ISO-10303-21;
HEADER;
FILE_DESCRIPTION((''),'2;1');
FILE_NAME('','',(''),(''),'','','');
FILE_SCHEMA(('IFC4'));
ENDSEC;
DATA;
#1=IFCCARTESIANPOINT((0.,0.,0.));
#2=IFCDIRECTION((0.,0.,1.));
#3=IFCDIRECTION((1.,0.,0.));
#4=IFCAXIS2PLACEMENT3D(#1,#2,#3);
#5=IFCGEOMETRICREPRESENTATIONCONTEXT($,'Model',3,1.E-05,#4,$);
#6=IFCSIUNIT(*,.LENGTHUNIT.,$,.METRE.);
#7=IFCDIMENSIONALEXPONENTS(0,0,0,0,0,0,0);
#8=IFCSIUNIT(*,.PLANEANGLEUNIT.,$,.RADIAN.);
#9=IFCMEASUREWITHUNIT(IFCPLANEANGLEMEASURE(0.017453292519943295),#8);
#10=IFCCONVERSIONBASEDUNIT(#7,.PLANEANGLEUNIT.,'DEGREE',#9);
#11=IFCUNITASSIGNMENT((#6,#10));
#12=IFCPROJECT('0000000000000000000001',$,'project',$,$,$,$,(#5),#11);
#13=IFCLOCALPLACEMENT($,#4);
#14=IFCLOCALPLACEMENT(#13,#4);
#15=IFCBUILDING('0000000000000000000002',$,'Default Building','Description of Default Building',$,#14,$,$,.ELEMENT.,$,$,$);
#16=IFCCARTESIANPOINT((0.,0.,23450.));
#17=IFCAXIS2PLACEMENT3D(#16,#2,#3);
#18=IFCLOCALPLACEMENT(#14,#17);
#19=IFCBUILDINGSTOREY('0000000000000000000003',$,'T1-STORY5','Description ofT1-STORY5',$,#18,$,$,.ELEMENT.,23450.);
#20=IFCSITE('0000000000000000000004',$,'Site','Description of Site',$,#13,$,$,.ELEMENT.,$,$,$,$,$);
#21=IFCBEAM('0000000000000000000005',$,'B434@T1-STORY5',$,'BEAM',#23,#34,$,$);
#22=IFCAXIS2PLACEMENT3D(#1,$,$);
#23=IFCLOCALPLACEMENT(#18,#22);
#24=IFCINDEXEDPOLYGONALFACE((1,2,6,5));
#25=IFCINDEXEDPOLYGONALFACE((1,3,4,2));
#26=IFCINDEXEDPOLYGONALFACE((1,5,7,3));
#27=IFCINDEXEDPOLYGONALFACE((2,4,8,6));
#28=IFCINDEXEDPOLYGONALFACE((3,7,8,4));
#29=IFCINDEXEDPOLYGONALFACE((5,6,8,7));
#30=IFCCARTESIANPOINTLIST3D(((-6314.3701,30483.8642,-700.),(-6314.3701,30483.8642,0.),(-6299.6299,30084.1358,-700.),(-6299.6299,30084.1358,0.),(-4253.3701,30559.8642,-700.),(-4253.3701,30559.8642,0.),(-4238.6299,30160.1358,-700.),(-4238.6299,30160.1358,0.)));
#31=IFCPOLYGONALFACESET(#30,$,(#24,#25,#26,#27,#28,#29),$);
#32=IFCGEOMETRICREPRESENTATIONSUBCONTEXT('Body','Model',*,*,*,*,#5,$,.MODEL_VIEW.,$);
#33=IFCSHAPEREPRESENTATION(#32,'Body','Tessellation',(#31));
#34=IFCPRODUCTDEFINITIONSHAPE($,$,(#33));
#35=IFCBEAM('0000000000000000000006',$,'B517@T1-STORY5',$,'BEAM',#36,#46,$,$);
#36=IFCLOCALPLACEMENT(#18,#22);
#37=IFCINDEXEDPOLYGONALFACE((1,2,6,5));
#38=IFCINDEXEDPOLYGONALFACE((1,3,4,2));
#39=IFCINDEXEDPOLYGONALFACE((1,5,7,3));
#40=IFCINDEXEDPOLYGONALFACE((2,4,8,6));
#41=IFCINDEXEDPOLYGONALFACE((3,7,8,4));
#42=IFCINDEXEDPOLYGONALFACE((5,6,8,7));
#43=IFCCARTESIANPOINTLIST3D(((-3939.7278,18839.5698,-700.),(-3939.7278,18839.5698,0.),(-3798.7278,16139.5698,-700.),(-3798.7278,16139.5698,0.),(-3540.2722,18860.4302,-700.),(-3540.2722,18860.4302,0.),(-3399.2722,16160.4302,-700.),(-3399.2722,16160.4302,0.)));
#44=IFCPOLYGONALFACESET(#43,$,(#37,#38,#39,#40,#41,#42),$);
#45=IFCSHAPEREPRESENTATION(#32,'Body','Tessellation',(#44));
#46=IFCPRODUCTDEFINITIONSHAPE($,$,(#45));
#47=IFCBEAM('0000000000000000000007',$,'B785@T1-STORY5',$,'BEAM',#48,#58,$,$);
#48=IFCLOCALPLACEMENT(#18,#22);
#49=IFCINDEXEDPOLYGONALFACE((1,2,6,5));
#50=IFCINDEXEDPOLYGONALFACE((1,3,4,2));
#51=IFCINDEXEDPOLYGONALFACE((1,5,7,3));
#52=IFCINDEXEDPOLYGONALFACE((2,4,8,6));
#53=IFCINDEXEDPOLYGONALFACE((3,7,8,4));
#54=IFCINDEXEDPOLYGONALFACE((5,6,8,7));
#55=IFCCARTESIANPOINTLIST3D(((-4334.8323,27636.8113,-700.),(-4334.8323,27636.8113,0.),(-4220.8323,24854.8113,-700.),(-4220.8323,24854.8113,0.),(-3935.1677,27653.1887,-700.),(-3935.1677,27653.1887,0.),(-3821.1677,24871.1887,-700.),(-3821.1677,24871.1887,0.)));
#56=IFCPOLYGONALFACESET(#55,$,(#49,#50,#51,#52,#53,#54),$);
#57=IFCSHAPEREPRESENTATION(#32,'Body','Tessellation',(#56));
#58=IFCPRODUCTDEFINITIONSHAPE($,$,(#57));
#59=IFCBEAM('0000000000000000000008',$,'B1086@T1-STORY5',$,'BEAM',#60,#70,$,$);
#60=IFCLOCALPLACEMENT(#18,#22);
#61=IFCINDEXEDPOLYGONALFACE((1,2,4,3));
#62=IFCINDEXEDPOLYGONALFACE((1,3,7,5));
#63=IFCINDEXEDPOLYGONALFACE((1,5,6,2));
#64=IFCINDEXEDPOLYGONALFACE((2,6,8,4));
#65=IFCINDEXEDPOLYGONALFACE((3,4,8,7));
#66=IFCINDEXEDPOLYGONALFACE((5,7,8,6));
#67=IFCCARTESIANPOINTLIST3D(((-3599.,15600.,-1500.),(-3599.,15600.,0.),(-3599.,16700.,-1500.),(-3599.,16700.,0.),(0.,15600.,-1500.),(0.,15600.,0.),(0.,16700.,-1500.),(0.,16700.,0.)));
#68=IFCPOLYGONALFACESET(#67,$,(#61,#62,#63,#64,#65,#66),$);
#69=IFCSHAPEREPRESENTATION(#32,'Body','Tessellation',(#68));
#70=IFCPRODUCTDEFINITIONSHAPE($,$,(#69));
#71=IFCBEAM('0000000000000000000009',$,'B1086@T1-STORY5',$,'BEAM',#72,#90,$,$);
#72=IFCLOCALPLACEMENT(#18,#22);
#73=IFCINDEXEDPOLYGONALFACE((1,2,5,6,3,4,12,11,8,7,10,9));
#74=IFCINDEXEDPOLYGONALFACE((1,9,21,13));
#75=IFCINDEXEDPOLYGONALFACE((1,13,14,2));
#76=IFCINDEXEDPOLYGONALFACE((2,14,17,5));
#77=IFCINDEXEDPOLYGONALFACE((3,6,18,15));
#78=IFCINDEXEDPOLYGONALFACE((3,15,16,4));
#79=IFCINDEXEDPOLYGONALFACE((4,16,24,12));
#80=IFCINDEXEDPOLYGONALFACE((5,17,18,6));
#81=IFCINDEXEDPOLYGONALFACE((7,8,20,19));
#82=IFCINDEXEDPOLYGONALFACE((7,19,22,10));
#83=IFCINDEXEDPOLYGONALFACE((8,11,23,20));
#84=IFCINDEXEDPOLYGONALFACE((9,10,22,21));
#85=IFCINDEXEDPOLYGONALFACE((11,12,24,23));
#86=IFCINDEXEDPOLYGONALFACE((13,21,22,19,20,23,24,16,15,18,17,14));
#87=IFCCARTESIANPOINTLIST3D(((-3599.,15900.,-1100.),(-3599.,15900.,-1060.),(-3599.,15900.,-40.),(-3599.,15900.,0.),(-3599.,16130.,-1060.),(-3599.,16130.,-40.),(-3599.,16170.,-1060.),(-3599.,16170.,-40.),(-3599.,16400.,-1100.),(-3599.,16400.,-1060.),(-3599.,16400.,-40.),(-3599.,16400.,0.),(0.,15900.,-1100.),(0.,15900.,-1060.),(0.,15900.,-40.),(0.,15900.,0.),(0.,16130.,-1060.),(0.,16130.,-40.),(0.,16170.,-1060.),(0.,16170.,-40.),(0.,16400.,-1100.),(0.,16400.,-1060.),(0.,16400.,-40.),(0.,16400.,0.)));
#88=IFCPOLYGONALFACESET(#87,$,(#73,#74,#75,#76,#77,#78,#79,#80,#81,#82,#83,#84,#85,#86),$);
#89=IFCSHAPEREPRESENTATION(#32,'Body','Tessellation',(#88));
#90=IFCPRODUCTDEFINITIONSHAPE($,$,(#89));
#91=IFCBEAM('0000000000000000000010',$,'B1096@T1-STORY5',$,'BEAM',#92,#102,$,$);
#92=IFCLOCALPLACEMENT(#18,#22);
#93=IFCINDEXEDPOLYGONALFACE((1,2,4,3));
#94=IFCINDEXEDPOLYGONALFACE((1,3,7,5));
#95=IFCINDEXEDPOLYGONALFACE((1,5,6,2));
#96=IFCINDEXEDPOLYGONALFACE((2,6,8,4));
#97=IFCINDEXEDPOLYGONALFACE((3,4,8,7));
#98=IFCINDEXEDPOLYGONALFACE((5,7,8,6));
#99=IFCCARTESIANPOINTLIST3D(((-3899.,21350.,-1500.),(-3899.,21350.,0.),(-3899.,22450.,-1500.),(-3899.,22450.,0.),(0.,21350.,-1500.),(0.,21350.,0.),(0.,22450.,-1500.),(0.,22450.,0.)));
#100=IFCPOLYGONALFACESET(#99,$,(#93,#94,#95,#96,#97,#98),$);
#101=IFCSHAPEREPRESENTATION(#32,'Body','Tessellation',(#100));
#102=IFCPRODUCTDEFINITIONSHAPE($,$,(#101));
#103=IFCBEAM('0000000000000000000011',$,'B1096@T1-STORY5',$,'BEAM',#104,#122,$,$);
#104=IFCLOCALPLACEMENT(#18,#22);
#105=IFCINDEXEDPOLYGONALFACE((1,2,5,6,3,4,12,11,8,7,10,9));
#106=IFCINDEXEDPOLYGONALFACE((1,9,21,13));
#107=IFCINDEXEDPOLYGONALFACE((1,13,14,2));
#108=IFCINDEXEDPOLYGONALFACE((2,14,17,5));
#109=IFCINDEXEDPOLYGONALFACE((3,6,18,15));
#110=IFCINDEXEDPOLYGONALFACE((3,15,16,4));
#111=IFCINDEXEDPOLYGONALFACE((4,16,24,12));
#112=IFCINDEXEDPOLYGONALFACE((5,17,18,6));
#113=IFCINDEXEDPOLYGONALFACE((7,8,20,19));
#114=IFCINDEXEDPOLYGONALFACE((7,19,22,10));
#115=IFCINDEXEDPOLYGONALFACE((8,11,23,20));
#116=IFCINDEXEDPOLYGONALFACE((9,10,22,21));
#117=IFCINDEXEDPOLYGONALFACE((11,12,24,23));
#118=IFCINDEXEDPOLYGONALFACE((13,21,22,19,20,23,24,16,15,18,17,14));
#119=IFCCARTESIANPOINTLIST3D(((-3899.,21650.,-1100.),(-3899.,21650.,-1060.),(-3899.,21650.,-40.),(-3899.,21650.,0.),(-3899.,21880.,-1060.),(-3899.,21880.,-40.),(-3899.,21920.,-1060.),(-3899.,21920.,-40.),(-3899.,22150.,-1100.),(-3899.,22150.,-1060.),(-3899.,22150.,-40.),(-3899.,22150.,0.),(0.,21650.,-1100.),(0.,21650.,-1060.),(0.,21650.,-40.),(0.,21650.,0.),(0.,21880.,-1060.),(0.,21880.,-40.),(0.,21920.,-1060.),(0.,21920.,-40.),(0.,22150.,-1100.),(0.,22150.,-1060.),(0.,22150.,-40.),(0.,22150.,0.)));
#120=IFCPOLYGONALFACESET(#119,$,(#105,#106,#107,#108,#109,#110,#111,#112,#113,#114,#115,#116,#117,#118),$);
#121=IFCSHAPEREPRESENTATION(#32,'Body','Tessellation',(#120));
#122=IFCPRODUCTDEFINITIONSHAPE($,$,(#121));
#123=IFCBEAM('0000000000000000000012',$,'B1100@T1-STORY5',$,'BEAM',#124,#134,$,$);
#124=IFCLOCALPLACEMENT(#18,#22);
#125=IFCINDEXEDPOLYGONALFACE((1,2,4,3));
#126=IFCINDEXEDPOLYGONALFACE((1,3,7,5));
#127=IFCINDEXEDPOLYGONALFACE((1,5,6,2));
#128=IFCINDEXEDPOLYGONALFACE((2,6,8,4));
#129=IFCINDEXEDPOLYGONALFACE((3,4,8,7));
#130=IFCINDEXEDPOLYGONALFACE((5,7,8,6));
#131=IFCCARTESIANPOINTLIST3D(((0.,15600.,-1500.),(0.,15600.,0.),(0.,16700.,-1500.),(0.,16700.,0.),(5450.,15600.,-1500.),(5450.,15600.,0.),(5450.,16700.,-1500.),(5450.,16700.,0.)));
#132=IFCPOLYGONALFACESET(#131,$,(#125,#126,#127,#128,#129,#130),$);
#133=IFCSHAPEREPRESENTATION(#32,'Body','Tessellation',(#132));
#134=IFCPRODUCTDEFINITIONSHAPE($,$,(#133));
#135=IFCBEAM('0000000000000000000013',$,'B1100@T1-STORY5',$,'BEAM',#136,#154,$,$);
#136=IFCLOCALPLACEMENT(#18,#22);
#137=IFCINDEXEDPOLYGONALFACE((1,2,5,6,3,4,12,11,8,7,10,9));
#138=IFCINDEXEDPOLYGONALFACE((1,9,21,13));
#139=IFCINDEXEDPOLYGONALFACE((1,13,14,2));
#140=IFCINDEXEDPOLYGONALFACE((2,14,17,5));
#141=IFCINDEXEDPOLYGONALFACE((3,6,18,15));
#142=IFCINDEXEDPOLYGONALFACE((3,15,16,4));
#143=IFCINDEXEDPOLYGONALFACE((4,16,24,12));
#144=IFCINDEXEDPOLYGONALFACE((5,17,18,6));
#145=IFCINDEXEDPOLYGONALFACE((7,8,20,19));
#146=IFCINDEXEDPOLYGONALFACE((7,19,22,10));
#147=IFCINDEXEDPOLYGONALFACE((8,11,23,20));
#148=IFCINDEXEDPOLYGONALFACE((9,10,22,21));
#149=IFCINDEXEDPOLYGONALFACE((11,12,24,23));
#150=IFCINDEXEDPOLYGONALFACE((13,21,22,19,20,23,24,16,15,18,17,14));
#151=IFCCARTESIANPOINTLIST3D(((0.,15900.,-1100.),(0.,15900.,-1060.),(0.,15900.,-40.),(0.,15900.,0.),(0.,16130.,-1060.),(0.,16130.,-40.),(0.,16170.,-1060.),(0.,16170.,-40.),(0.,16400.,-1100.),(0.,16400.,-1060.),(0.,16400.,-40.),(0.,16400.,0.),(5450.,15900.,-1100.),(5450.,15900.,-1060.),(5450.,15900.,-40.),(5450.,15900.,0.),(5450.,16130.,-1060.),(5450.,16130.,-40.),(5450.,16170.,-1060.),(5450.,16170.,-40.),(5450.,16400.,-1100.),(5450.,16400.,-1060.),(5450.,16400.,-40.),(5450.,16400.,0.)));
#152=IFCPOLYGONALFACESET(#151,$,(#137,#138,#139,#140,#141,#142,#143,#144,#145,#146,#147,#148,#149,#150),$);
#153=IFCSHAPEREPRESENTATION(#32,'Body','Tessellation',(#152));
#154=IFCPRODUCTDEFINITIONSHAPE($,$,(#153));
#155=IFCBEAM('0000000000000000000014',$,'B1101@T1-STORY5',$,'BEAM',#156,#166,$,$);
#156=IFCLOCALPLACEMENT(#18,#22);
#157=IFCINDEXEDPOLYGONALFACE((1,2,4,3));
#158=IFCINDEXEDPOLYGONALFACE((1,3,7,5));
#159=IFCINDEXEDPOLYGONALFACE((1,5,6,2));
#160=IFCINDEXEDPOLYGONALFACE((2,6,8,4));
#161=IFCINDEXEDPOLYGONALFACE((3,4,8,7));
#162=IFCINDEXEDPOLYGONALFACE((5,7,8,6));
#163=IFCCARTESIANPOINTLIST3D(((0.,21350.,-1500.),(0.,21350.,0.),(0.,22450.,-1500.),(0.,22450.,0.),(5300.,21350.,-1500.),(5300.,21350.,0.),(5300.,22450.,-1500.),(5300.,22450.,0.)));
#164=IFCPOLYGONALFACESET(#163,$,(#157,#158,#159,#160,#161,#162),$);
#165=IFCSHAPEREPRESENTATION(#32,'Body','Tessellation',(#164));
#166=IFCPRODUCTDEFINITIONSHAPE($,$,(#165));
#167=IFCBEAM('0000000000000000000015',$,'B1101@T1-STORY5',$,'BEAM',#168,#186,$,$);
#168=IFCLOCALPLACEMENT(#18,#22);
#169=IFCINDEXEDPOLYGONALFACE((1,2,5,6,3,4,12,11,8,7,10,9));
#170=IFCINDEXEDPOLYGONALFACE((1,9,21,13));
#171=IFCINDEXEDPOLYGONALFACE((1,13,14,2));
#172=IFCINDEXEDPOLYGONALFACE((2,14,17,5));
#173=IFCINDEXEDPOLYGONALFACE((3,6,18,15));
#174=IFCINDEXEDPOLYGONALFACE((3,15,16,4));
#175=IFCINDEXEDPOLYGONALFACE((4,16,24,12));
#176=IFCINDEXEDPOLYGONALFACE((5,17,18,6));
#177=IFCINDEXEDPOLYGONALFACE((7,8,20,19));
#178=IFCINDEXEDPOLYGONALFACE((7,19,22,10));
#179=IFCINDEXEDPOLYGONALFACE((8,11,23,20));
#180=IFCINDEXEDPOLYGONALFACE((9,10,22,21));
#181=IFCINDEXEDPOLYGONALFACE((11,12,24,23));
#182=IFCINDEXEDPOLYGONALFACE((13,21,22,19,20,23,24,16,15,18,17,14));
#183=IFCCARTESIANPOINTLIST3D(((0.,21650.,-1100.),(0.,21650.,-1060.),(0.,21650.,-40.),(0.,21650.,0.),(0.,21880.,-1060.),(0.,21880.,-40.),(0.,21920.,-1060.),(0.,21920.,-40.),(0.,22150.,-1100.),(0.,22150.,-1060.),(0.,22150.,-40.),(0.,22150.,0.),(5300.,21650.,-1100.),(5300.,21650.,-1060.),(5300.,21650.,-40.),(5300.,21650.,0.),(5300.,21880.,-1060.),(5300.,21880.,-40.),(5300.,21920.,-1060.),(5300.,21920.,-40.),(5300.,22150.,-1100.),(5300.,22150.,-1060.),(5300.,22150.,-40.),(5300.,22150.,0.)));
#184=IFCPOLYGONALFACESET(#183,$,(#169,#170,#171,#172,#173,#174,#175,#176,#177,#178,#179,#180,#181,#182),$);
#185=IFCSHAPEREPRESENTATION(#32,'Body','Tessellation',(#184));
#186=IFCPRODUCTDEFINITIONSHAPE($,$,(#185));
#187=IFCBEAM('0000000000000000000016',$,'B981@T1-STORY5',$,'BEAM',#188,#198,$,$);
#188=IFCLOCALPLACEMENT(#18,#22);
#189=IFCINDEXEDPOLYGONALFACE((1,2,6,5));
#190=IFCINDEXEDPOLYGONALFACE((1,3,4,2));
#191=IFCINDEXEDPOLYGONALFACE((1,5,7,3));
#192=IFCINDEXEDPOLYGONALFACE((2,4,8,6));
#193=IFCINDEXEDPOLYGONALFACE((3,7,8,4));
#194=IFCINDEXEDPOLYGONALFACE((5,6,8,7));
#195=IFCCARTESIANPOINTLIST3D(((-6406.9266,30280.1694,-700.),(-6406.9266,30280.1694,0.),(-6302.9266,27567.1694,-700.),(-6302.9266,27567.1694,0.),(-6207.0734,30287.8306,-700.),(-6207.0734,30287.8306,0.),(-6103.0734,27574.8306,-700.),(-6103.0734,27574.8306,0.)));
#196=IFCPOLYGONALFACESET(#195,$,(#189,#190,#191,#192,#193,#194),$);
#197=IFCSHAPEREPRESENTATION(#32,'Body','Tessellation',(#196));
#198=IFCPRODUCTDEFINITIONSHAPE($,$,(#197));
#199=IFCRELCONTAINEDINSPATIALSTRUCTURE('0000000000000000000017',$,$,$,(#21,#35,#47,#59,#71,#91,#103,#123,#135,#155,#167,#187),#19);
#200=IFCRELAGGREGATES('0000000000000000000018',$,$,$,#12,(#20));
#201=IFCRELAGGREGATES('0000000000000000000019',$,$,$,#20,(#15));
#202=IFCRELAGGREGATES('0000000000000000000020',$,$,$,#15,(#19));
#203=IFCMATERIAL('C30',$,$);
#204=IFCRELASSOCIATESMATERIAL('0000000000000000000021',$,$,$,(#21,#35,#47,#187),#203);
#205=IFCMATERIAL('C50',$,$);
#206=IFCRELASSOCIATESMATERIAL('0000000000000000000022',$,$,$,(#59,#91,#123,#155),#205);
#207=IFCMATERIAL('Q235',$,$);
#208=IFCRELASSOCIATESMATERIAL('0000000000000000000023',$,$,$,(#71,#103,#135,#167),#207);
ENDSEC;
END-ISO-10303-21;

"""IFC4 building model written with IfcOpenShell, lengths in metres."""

from ifc_helpers import new_model, entity, si_unit, converted_unit, frame, origin_with_axes, place, context, subcontext, project, spatial, rectangle, i_section, extrude, material, element, save


model = new_model("IFC4")

# Units and contexts
model_context = context("Model", 3, precision=1e-05, world=origin_with_axes())
body_context = subcontext(model_context, "Body", "Model", "MODEL_VIEW")
ifc_project = project(units=[si_unit("LENGTHUNIT", "METRE"), converted_unit("PLANEANGLEUNIT", "DEGREE", entity("IfcPlaneAngleMeasure", 0.017453292519943295), si_unit("PLANEANGLEUNIT", "RADIAN"), dimensions=[0, 0, 0, 0, 0, 0, 0])], contexts=[model_context])

# Site, building, storey
site_placement = place(None, origin_with_axes())
site = spatial("IfcSite", under=ifc_project, at=site_placement, Name="Site", Description="Description of Site", CompositionType="ELEMENT")
building_placement = place(site_placement, origin_with_axes())
building = spatial("IfcBuilding", under=site, at=building_placement, Name="Default Building", Description="Description of Default Building", CompositionType="ELEMENT")
storey_placement = place(building_placement, frame((0.0, 0.0, 23450.0), z_axis=(0.0, 0.0, 1.0), x_axis=(1.0, 0.0, 0.0)))
storey = spatial("IfcBuildingStorey", under=building, at=storey_placement, Name="T1-STORY5", Description="Description ofT1-STORY5", CompositionType="ELEMENT", Elevation=23450.0)

# Beams
ifc_material_1 = material(Name="C30")
beam_1_placement = place(storey_placement, frame((-6307.0, 30284.0, -350.0), z_axis=(0.999321, 0.03685, 0.0), x_axis=(-0.03685, 0.999321, 0.0)))
element("IfcBeam", 1, at=beam_1_placement, inside=storey, material=ifc_material_1, Name="B434@T1-STORY5", ObjectType="BEAM", context=body_context, shape_type="SweptSolid", body=[
    extrude(rectangle(XDim=400.0, YDim=700.0), origin_with_axes(), (0.0, 0.0, 1.0), 2062.4008),
])
beam_2_placement = place(storey_placement, frame((-3740.0, 18850.0, -350.0), z_axis=(0.052151, -0.998639, 0.0), x_axis=(0.998639, 0.052151, 0.0)))
element("IfcBeam", 2, at=beam_2_placement, inside=storey, material=ifc_material_1, Name="B517@T1-STORY5", ObjectType="BEAM", context=body_context, shape_type="SweptSolid", body=[
    extrude(rectangle(XDim=400.0, YDim=700.0), origin_with_axes(), (0.0, 0.0, 1.0), 2703.6792),
])
beam_3_placement = place(storey_placement, frame((-4135.0, 27645.0, -350.0), z_axis=(0.040943, -0.999161, 0.0), x_axis=(0.999161, 0.040943, 0.0)))
element("IfcBeam", 3, at=beam_3_placement, inside=storey, material=ifc_material_1, Name="B785@T1-STORY5", ObjectType="BEAM", context=body_context, shape_type="SweptSolid", body=[
    extrude(rectangle(XDim=400.0, YDim=700.0), origin_with_axes(), (0.0, 0.0, 1.0), 2784.3347),
])
ifc_material_2 = material(Name="C50")
beam_4_placement = place(storey_placement, frame((-3599.0, 16150.0, -750.0), z_axis=(1.0, 0.0, 0.0), x_axis=(0.0, 1.0, 0.0)))
element("IfcBeam", 4, at=beam_4_placement, inside=storey, material=ifc_material_2, Name="B1086@T1-STORY5", ObjectType="BEAM", context=body_context, shape_type="SweptSolid", body=[
    extrude(rectangle(XDim=1100.0, YDim=1500.0), origin_with_axes(), (0.0, 0.0, 1.0), 3599.0),
])
ifc_material_3 = material(Name="Q235")
beam_5_placement = place(storey_placement, frame((-3599.0, 16150.0, -550.0), z_axis=(1.0, 0.0, 0.0), x_axis=(0.0, 1.0, 0.0)))
element("IfcBeam", 5, at=beam_5_placement, inside=storey, material=ifc_material_3, Name="B1086@T1-STORY5", ObjectType="BEAM", context=body_context, shape_type="SweptSolid", body=[
    extrude(i_section(OverallWidth=500.0, OverallDepth=1100.0, WebThickness=40.0, FlangeThickness=40.0, FilletRadius=0.0), origin_with_axes(), (0.0, 0.0, 1.0), 3599.0),
])
beam_6_placement = place(storey_placement, frame((-3899.0, 21900.0, -750.0), z_axis=(1.0, 0.0, 0.0), x_axis=(0.0, 1.0, 0.0)))
element("IfcBeam", 6, at=beam_6_placement, inside=storey, material=ifc_material_2, Name="B1096@T1-STORY5", ObjectType="BEAM", context=body_context, shape_type="SweptSolid", body=[
    extrude(rectangle(XDim=1100.0, YDim=1500.0), origin_with_axes(), (0.0, 0.0, 1.0), 3899.0),
])
beam_7_placement = place(storey_placement, frame((-3899.0, 21900.0, -550.0), z_axis=(1.0, 0.0, 0.0), x_axis=(0.0, 1.0, 0.0)))
element("IfcBeam", 7, at=beam_7_placement, inside=storey, material=ifc_material_3, Name="B1096@T1-STORY5", ObjectType="BEAM", context=body_context, shape_type="SweptSolid", body=[
    extrude(i_section(OverallWidth=500.0, OverallDepth=1100.0, WebThickness=40.0, FlangeThickness=40.0, FilletRadius=0.0), origin_with_axes(), (0.0, 0.0, 1.0), 3899.0),
])
beam_8_placement = place(storey_placement, frame((0.0, 16150.0, -750.0), z_axis=(1.0, 0.0, 0.0), x_axis=(0.0, 1.0, 0.0)))
element("IfcBeam", 8, at=beam_8_placement, inside=storey, material=ifc_material_2, Name="B1100@T1-STORY5", ObjectType="BEAM", context=body_context, shape_type="SweptSolid", body=[
    extrude(rectangle(XDim=1100.0, YDim=1500.0), origin_with_axes(), (0.0, 0.0, 1.0), 5450.0),
])
beam_9_placement = place(storey_placement, frame((0.0, 16150.0, -550.0), z_axis=(1.0, 0.0, 0.0), x_axis=(0.0, 1.0, 0.0)))
element("IfcBeam", 9, at=beam_9_placement, inside=storey, material=ifc_material_3, Name="B1100@T1-STORY5", ObjectType="BEAM", context=body_context, shape_type="SweptSolid", body=[
    extrude(i_section(OverallWidth=500.0, OverallDepth=1100.0, WebThickness=40.0, FlangeThickness=40.0, FilletRadius=0.0), origin_with_axes(), (0.0, 0.0, 1.0), 5450.0),
])
beam_10_placement = place(storey_placement, frame((0.0, 21900.0, -750.0), z_axis=(1.0, 0.0, 0.0), x_axis=(0.0, 1.0, 0.0)))
element("IfcBeam", 10, at=beam_10_placement, inside=storey, material=ifc_material_2, Name="B1101@T1-STORY5", ObjectType="BEAM", context=body_context, shape_type="SweptSolid", body=[
    extrude(rectangle(XDim=1100.0, YDim=1500.0), origin_with_axes(), (0.0, 0.0, 1.0), 5300.0),
])
beam_11_placement = place(storey_placement, frame((0.0, 21900.0, -550.0), z_axis=(1.0, 0.0, 0.0), x_axis=(0.0, 1.0, 0.0)))
element("IfcBeam", 11, at=beam_11_placement, inside=storey, material=ifc_material_3, Name="B1101@T1-STORY5", ObjectType="BEAM", context=body_context, shape_type="SweptSolid", body=[
    extrude(i_section(OverallWidth=500.0, OverallDepth=1100.0, WebThickness=40.0, FlangeThickness=40.0, FilletRadius=0.0), origin_with_axes(), (0.0, 0.0, 1.0), 5300.0),
])
beam_12_placement = place(storey_placement, frame((-6307.0, 30284.0, -350.0), z_axis=(0.038306, -0.999266, 0.0), x_axis=(0.999266, 0.038306, 0.0)))
element("IfcBeam", 12, at=beam_12_placement, inside=storey, material=ifc_material_1, Name="B981@T1-STORY5", ObjectType="BEAM", context=body_context, shape_type="SweptSolid", body=[
    extrude(rectangle(XDim=200.0, YDim=700.0), origin_with_axes(), (0.0, 0.0, 1.0), 2714.9926),
])

save(model, "model.ifc")
